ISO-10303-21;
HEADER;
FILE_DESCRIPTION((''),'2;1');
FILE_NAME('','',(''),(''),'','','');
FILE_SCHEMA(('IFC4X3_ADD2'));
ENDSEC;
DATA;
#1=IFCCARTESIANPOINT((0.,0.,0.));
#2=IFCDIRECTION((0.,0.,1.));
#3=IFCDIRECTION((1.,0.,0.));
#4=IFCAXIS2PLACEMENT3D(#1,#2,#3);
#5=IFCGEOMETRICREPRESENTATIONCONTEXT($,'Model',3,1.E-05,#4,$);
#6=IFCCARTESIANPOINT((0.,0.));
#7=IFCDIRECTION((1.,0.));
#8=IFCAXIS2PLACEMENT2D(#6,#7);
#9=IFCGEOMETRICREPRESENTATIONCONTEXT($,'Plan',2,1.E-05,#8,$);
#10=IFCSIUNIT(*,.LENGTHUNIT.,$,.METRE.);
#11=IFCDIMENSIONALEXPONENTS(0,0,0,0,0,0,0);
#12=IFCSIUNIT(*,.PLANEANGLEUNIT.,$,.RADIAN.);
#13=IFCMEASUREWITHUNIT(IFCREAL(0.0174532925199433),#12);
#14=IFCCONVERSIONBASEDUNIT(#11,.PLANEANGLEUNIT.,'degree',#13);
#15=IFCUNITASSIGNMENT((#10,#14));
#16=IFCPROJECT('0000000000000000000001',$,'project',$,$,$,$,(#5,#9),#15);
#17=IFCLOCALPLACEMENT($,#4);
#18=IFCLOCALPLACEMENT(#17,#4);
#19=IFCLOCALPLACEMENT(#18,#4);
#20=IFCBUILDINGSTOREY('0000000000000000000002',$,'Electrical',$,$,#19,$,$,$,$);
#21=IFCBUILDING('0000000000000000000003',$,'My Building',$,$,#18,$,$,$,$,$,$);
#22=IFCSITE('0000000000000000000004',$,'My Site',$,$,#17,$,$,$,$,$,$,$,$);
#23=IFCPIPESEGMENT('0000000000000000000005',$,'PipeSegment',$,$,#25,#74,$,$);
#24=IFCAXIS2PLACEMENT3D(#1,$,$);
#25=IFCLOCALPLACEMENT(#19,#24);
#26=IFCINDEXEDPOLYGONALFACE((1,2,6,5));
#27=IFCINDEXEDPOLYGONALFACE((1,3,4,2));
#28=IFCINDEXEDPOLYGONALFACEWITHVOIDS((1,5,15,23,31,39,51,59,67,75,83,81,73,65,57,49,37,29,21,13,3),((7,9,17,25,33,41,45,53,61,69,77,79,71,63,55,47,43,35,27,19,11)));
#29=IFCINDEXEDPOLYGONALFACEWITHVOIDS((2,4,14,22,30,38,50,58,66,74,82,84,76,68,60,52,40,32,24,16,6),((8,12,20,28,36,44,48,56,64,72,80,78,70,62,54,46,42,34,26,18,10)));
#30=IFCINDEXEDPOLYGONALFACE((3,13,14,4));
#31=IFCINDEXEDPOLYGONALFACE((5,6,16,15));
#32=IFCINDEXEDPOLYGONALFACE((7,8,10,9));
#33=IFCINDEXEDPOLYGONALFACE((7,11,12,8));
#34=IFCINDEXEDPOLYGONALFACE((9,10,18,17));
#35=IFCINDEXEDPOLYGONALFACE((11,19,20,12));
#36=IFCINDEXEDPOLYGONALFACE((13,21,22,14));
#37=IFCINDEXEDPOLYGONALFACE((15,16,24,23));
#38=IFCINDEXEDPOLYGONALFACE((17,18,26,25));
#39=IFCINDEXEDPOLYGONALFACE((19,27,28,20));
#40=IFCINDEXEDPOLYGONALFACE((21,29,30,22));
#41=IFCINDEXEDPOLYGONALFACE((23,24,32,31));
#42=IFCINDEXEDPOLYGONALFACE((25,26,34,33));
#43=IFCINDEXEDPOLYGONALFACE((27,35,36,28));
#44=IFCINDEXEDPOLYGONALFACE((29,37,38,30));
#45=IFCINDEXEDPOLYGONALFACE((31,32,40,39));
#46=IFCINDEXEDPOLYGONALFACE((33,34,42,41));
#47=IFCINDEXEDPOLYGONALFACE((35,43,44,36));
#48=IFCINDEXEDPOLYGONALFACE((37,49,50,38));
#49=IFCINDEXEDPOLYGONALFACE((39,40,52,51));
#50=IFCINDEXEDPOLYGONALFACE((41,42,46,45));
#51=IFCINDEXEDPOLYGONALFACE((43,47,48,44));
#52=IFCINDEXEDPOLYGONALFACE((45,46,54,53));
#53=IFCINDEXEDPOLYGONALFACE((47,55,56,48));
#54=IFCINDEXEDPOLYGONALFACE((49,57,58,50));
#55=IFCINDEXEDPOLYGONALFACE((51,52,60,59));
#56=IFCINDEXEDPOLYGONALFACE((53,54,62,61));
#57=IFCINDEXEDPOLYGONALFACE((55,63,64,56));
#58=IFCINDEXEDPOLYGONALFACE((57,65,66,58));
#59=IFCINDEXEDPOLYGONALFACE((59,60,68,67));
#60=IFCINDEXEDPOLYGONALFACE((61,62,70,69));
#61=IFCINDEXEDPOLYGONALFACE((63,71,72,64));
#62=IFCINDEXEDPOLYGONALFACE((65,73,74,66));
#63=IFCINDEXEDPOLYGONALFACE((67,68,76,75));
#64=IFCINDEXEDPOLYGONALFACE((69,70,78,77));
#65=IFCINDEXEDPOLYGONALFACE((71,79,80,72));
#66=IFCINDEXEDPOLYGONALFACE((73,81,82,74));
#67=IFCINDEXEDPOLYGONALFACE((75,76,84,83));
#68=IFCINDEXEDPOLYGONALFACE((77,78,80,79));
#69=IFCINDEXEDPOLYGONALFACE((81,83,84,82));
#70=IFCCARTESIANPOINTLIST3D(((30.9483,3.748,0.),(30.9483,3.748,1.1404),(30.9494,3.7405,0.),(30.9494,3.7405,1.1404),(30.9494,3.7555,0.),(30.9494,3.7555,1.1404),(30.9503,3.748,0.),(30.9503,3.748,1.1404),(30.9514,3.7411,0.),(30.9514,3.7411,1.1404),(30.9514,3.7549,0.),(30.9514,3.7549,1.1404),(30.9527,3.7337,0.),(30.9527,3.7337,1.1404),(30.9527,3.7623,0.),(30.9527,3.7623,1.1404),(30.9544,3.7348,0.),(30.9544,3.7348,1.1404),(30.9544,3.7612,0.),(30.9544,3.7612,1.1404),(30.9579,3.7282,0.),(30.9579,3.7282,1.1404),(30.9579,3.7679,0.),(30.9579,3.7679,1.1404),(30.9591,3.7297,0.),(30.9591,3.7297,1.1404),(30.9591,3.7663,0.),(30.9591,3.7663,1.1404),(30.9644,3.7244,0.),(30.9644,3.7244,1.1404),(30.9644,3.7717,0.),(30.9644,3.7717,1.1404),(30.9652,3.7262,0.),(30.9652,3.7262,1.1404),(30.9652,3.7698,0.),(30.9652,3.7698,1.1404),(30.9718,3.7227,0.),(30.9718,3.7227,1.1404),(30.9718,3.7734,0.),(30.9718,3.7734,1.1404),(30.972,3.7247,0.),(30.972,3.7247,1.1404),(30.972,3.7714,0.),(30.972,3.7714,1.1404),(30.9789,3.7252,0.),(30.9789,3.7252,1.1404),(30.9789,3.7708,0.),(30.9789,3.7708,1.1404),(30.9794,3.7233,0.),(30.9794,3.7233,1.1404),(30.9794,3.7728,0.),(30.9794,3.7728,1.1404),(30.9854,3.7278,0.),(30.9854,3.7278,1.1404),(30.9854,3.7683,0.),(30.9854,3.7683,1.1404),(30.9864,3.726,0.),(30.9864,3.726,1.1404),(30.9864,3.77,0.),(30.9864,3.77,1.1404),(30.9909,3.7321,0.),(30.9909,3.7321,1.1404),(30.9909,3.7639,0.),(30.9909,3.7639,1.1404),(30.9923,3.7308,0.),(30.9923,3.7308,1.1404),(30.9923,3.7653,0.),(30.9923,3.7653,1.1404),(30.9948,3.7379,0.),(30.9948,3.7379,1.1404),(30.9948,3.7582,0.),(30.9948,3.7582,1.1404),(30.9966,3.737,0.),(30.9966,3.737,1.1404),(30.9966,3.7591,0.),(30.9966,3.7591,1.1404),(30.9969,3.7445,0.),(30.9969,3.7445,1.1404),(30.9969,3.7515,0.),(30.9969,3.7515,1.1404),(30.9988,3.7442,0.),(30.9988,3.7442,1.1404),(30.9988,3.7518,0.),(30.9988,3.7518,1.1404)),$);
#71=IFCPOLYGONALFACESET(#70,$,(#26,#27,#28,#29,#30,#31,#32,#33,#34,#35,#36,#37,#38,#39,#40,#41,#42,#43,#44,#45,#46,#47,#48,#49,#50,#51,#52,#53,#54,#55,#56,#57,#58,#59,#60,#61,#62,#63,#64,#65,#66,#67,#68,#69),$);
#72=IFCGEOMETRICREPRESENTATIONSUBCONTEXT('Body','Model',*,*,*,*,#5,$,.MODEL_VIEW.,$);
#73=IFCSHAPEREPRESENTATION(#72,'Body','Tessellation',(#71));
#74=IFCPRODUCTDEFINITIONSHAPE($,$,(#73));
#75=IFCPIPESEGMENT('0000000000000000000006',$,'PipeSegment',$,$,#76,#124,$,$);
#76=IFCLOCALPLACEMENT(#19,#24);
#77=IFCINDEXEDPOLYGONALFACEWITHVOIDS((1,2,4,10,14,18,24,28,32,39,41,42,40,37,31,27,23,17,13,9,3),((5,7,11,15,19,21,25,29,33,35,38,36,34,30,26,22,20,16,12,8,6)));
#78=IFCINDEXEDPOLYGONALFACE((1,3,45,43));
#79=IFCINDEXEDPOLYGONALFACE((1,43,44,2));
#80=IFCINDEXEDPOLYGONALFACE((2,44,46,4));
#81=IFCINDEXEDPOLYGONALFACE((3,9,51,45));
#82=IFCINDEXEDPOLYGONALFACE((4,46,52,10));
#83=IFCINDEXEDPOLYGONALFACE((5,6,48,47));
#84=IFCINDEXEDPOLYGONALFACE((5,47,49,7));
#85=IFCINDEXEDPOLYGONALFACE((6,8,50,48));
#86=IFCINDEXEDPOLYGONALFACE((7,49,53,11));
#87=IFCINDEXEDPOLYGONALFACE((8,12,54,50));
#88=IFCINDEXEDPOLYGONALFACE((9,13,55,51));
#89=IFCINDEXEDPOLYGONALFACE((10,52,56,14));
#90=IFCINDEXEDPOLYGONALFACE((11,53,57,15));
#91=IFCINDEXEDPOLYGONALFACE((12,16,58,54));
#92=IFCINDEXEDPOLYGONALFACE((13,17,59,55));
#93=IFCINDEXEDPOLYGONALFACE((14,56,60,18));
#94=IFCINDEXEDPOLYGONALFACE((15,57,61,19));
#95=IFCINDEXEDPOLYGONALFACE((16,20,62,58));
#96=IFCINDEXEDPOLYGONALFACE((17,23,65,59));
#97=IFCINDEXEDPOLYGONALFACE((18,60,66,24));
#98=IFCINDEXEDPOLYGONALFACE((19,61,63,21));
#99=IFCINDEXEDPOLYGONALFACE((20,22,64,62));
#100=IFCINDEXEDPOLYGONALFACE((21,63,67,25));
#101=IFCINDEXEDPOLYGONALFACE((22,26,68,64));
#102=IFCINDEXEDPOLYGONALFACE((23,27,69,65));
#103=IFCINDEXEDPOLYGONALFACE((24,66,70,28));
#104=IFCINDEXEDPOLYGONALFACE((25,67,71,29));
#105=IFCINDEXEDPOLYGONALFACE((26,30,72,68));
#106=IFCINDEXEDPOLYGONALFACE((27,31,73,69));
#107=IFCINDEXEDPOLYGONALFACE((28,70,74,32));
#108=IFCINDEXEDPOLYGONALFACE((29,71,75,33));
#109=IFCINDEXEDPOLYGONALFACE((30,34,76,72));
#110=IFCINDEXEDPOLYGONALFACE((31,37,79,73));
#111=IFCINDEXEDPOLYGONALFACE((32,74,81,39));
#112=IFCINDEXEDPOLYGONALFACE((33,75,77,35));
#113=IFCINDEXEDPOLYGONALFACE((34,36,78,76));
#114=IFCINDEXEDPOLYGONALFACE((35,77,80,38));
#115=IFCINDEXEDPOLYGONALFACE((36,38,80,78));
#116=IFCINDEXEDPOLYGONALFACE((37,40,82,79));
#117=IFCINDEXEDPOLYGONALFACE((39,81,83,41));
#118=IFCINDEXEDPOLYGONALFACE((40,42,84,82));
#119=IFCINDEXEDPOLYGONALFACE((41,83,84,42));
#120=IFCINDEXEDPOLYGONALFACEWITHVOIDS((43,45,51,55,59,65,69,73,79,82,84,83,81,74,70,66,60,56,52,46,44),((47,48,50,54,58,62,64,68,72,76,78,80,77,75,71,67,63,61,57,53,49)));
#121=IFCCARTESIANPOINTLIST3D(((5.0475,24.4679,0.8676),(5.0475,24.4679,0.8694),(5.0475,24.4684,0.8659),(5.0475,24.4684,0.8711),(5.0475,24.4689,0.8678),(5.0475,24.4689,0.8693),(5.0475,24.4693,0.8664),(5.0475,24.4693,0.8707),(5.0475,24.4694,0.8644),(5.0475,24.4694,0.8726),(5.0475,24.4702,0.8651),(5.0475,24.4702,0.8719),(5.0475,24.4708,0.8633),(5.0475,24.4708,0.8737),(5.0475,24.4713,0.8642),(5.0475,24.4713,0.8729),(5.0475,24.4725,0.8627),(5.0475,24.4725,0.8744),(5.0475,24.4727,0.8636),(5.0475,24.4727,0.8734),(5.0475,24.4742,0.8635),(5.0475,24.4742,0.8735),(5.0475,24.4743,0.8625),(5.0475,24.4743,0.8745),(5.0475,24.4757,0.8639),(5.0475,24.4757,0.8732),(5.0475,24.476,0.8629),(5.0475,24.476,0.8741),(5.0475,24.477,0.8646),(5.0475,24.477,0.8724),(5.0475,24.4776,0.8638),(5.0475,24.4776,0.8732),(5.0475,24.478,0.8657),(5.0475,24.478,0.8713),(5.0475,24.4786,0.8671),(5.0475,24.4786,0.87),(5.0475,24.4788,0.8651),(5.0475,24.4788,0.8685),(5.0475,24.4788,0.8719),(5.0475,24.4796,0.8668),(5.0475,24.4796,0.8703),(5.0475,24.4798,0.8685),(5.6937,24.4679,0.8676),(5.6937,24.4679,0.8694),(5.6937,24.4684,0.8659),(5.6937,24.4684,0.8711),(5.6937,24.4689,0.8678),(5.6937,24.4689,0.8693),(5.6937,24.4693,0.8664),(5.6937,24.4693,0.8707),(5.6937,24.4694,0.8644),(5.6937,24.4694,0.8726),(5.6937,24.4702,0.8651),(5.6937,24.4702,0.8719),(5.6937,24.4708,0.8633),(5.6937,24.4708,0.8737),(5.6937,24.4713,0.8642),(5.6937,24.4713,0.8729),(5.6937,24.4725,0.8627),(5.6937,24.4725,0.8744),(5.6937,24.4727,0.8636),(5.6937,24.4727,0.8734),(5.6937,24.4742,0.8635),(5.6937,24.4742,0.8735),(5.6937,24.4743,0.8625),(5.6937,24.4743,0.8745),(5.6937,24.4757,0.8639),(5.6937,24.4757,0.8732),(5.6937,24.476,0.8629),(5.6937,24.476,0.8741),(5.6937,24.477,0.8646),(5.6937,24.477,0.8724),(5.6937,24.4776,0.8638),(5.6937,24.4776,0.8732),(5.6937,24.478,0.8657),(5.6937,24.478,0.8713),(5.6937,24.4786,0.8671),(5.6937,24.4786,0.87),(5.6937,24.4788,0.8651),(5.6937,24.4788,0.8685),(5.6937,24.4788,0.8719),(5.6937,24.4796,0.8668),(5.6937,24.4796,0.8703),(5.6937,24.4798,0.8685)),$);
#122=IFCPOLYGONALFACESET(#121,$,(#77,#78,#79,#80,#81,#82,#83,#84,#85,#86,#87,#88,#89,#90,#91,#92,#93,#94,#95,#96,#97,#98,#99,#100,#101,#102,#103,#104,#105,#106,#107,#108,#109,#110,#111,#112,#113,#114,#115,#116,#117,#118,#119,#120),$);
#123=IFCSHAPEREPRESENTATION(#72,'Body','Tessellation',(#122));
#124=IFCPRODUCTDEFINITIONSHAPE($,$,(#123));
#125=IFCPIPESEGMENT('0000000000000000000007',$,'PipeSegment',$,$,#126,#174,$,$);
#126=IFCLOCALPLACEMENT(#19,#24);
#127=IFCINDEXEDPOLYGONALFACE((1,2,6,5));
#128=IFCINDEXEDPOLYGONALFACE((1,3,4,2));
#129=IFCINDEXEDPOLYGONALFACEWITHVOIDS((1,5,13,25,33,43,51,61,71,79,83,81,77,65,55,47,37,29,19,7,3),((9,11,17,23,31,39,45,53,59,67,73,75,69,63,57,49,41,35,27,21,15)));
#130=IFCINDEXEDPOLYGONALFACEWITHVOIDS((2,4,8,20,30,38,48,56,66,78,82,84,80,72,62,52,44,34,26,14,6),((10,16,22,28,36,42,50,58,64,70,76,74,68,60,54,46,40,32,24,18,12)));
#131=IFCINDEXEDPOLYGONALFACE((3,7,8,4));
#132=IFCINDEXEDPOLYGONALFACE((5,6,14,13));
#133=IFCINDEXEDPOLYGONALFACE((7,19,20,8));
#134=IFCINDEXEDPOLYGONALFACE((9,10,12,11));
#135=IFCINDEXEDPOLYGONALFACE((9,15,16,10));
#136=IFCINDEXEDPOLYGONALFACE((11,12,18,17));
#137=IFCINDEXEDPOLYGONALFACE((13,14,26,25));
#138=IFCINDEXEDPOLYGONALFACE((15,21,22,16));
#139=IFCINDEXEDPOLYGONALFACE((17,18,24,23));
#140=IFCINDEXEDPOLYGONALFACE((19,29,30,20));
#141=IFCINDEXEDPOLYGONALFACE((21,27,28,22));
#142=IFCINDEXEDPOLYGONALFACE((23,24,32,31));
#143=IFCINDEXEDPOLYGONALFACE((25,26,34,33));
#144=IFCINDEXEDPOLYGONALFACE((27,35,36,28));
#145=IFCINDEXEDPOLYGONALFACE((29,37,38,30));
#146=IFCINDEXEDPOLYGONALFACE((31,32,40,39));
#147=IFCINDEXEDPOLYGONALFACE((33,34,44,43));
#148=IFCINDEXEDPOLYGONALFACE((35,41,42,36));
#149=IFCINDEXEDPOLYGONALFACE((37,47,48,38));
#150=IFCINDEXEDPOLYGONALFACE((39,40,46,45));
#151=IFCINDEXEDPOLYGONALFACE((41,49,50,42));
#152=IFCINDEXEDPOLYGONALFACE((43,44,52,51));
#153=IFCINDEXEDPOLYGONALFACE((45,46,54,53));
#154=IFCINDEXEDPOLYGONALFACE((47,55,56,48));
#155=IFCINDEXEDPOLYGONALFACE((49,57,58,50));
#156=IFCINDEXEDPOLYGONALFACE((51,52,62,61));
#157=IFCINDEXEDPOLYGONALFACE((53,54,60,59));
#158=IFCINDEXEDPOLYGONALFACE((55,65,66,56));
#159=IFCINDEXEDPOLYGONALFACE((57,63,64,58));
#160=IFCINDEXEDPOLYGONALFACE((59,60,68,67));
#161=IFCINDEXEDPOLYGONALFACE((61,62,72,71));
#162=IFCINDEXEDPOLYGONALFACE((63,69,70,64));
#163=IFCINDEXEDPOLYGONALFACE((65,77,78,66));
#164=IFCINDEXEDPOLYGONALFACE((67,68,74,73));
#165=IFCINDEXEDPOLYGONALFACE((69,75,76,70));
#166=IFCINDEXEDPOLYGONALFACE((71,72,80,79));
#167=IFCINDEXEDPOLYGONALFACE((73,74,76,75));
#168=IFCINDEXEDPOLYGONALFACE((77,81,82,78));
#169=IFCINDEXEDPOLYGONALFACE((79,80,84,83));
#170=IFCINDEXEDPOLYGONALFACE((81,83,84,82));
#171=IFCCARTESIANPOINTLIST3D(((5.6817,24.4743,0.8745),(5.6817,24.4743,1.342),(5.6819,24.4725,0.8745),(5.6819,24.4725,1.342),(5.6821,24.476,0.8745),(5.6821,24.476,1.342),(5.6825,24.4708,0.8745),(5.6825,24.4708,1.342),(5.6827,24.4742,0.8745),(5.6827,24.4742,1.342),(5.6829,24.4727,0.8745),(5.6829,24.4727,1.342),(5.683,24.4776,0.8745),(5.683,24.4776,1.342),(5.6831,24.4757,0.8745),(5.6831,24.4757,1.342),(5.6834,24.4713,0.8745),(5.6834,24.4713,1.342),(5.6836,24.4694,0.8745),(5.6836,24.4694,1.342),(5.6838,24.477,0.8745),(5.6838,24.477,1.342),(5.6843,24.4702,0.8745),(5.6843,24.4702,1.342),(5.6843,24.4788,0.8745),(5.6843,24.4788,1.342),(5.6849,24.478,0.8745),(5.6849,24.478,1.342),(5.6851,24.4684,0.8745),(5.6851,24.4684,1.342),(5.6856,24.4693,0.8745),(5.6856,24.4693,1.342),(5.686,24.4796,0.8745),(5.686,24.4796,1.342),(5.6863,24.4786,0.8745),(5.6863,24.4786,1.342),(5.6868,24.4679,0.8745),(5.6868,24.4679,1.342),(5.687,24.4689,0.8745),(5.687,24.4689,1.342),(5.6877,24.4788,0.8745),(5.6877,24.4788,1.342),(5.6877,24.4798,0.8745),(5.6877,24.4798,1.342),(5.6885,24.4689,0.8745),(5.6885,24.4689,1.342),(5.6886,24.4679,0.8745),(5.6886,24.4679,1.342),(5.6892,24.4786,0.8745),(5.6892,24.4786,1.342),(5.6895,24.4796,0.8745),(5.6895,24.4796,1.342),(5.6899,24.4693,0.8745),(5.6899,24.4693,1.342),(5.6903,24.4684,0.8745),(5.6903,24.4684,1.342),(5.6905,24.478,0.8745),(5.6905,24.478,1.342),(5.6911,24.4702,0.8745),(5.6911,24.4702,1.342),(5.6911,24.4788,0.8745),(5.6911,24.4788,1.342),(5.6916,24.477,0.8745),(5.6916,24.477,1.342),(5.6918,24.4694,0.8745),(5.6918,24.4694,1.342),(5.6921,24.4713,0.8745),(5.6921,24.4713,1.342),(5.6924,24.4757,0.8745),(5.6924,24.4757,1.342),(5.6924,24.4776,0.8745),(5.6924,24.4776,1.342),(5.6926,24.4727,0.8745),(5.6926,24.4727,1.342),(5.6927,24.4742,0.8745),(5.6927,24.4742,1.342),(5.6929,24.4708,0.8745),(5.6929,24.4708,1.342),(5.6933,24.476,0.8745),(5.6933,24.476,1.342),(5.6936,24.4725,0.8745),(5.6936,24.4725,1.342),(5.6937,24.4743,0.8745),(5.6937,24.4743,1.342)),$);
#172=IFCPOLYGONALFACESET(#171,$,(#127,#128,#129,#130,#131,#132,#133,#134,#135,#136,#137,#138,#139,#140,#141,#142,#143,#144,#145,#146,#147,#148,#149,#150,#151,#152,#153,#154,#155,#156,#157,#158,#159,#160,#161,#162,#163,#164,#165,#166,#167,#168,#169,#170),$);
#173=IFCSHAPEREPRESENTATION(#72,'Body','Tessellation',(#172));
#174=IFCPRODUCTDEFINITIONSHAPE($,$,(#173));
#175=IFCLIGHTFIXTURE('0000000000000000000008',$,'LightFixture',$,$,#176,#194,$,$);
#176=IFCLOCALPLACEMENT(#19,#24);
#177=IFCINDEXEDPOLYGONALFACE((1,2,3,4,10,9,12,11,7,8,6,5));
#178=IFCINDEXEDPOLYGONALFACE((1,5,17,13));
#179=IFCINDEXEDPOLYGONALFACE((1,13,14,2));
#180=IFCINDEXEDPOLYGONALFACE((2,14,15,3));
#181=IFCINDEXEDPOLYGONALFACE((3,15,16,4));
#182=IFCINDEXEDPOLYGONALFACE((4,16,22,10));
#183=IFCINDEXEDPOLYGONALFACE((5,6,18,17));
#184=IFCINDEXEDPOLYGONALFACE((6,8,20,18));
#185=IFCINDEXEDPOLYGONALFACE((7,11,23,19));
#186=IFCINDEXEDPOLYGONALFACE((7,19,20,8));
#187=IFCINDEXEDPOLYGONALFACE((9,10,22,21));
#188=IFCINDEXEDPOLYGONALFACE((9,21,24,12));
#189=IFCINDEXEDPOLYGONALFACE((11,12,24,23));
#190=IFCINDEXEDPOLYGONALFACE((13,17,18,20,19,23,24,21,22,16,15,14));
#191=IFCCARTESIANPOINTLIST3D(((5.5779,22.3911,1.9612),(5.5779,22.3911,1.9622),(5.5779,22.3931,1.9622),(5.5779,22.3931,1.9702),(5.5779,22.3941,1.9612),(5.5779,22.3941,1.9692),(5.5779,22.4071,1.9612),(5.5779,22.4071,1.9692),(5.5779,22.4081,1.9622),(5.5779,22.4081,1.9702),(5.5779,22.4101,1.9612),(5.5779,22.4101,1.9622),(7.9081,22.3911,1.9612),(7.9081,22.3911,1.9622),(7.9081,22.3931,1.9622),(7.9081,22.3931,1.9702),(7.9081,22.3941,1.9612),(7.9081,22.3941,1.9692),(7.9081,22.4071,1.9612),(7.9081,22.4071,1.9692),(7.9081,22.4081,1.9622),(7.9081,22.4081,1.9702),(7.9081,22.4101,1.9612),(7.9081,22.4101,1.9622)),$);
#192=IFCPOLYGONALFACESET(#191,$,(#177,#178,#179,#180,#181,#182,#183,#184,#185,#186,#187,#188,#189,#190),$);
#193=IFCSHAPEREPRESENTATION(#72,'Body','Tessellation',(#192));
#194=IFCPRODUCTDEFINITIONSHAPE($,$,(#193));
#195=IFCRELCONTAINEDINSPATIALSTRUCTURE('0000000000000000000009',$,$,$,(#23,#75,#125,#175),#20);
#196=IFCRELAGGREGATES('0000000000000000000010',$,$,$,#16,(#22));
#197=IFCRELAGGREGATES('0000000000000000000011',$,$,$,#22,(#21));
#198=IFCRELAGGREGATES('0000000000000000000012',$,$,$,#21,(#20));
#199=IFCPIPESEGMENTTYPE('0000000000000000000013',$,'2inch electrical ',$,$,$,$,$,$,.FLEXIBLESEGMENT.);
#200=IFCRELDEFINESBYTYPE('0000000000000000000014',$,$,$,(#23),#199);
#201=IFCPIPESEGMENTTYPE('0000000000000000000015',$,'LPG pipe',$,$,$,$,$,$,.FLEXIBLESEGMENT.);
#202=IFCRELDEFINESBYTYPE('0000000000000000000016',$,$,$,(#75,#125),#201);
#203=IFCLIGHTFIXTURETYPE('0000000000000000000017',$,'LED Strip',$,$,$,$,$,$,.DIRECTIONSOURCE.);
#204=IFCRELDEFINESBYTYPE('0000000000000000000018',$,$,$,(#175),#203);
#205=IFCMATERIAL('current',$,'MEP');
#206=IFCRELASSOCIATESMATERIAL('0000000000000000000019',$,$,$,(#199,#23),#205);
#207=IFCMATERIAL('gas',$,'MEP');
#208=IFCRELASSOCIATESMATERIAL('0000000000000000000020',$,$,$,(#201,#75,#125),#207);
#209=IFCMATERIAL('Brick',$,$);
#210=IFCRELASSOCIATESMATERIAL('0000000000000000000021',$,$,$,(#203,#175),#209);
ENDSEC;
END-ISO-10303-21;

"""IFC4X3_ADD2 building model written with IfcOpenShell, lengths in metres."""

from ifc_helpers import new_model, entity, si_unit, converted_unit, frame, origin_with_axes, origin_2d_with_axis, place, context, subcontext, project, spatial, indexed_curve, hollow_circle, outline, extrude, material, material_profile, profile_set, profile_usage, type_object, element, save


model = new_model("IFC4X3_ADD2")

# Units and contexts
model_context = context("Model", 3, precision=1e-05, world=origin_with_axes())
plan_context = context("Plan", 2, precision=1e-05, world=origin_2d_with_axis())
body_context = subcontext(model_context, "Body", "Model", "MODEL_VIEW")
ifc_project = project(units=[si_unit("LENGTHUNIT", "METRE"), converted_unit("PLANEANGLEUNIT", "degree", entity("IfcReal", 0.0174532925199433), si_unit("PLANEANGLEUNIT", "RADIAN"), dimensions=[0, 0, 0, 0, 0, 0, 0])], contexts=[model_context, plan_context])

# Site, building, storey
site_placement = place(None, origin_with_axes())
site = spatial("IfcSite", under=ifc_project, at=site_placement, Name="My Site")
building_placement = place(site_placement, origin_with_axes())
building = spatial("IfcBuilding", under=site, at=building_placement, Name="My Building")
storey_placement = place(building_placement, origin_with_axes())
storey = spatial("IfcBuildingStorey", under=building, at=storey_placement, Name="Electrical")

# Shared definitions
ifc_material_1 = material(Name="Brick")

# Pipe segments
ifc_material_2 = material(Name="current", Category="MEP")
ifc_material_profile_1 = material_profile(ifc_material_2, hollow_circle(Radius=0.0254, WallThickness=0.002))
ifc_profile_set_1 = profile_set([ifc_material_profile_1], Name="current")
ifc_profile_usage_1 = profile_usage(ifc_profile_set_1, cardinal=5)
pipe_segment_type_1 = type_object("IfcPipeSegmentType", Name="2inch electrical ", PredefinedType="FLEXIBLESEGMENT", material=ifc_profile_set_1)
pipe_segment_1_placement = place(storey_placement, frame((30.9737, 3.748, 1.1404), z_axis=(0.0, 0.0, -1.0), x_axis=(-1.0, 0.0, 0.0)))
element("IfcPipeSegment", 1, at=pipe_segment_1_placement, inside=storey, type_object=pipe_segment_type_1, material=ifc_profile_usage_1, Name="PipeSegment", context=body_context, shape_type="SweptSolid", body=[
    extrude(hollow_circle(Radius=0.0254, WallThickness=0.002), origin_with_axes(), (0.0, 0.0, 1.0), 1.1404),
])
ifc_material_3 = material(Name="gas", Category="MEP")
ifc_material_profile_2 = material_profile(ifc_material_3, hollow_circle(Radius=0.006, WallThickness=0.001))
ifc_profile_set_2 = profile_set([ifc_material_profile_2], Name="gas")
ifc_profile_usage_2 = profile_usage(ifc_profile_set_2)
pipe_segment_type_2 = type_object("IfcPipeSegmentType", Name="LPG pipe", PredefinedType="FLEXIBLESEGMENT", material=ifc_profile_set_2)
pipe_segment_2_placement = place(storey_placement, frame((5.0475, 24.4738, 0.8685), z_axis=(1.0, 0.0, 0.0), x_axis=(0.0, 1.0, 0.0)))
element("IfcPipeSegment", 2, at=pipe_segment_2_placement, inside=storey, type_object=pipe_segment_type_2, material=ifc_profile_usage_2, Name="PipeSegment", context=body_context, shape_type="SweptSolid", body=[
    extrude(hollow_circle(Radius=0.006, WallThickness=0.001), origin_with_axes(), (0.0, 0.0, 1.0), 0.6462),
])
ifc_profile_usage_3 = profile_usage(ifc_profile_set_2)
pipe_segment_3_placement = place(storey_placement, frame((5.6877, 24.4738, 0.8745), z_axis=(0.0, 0.0, 1.0), x_axis=(0.0, 1.0, 0.0)))
element("IfcPipeSegment", 3, at=pipe_segment_3_placement, inside=storey, type_object=pipe_segment_type_2, material=ifc_profile_usage_3, Name="PipeSegment", context=body_context, shape_type="SweptSolid", body=[
    extrude(hollow_circle(Radius=0.006, WallThickness=0.001), origin_with_axes(), (0.0, 0.0, 1.0), 0.4675),
])

# Light fixture
ifc_material_profile_3 = material_profile(ifc_material_1, outline(indexed_curve([(0.003, 0.0), (0.003, 0.008), (0.016, 0.008), (0.016, 0.0), (0.019, 0.0), (0.019, 0.001), (0.017, 0.001), (0.017, 0.009), (0.002, 0.009), (0.002, 0.001), (0.0, 0.001), (0.0, 0.0), (0.003, 0.0)])))
ifc_profile_set_3 = profile_set([ifc_material_profile_3])
ifc_profile_usage_4 = profile_usage(ifc_profile_set_3, cardinal=5)
light_fixture_type = type_object("IfcLightFixtureType", Name="LED Strip", PredefinedType="DIRECTIONSOURCE", material=ifc_profile_set_3)
light_fixture_1_placement = place(storey_placement, frame((7.9081, 22.4101, 1.9612), z_axis=(-1.0, 0.0, 0.0), x_axis=(0.0, -1.0, 0.0)))
element("IfcLightFixture", 4, at=light_fixture_1_placement, inside=storey, type_object=light_fixture_type, material=ifc_profile_usage_4, Name="LightFixture", context=body_context, shape_type="SweptSolid", body=[
    extrude(outline(indexed_curve([(0.003, 0.0), (0.003, 0.008), (0.016, 0.008), (0.016, 0.0), (0.019, 0.0), (0.019, 0.001), (0.017, 0.001), (0.017, 0.009), (0.002, 0.009), (0.002, 0.001), (0.0, 0.001), (0.0, 0.0), (0.003, 0.0)])), origin_with_axes(), (0.0, 0.0, 1.0), 2.3302),
])

save(model, "model.ifc")
